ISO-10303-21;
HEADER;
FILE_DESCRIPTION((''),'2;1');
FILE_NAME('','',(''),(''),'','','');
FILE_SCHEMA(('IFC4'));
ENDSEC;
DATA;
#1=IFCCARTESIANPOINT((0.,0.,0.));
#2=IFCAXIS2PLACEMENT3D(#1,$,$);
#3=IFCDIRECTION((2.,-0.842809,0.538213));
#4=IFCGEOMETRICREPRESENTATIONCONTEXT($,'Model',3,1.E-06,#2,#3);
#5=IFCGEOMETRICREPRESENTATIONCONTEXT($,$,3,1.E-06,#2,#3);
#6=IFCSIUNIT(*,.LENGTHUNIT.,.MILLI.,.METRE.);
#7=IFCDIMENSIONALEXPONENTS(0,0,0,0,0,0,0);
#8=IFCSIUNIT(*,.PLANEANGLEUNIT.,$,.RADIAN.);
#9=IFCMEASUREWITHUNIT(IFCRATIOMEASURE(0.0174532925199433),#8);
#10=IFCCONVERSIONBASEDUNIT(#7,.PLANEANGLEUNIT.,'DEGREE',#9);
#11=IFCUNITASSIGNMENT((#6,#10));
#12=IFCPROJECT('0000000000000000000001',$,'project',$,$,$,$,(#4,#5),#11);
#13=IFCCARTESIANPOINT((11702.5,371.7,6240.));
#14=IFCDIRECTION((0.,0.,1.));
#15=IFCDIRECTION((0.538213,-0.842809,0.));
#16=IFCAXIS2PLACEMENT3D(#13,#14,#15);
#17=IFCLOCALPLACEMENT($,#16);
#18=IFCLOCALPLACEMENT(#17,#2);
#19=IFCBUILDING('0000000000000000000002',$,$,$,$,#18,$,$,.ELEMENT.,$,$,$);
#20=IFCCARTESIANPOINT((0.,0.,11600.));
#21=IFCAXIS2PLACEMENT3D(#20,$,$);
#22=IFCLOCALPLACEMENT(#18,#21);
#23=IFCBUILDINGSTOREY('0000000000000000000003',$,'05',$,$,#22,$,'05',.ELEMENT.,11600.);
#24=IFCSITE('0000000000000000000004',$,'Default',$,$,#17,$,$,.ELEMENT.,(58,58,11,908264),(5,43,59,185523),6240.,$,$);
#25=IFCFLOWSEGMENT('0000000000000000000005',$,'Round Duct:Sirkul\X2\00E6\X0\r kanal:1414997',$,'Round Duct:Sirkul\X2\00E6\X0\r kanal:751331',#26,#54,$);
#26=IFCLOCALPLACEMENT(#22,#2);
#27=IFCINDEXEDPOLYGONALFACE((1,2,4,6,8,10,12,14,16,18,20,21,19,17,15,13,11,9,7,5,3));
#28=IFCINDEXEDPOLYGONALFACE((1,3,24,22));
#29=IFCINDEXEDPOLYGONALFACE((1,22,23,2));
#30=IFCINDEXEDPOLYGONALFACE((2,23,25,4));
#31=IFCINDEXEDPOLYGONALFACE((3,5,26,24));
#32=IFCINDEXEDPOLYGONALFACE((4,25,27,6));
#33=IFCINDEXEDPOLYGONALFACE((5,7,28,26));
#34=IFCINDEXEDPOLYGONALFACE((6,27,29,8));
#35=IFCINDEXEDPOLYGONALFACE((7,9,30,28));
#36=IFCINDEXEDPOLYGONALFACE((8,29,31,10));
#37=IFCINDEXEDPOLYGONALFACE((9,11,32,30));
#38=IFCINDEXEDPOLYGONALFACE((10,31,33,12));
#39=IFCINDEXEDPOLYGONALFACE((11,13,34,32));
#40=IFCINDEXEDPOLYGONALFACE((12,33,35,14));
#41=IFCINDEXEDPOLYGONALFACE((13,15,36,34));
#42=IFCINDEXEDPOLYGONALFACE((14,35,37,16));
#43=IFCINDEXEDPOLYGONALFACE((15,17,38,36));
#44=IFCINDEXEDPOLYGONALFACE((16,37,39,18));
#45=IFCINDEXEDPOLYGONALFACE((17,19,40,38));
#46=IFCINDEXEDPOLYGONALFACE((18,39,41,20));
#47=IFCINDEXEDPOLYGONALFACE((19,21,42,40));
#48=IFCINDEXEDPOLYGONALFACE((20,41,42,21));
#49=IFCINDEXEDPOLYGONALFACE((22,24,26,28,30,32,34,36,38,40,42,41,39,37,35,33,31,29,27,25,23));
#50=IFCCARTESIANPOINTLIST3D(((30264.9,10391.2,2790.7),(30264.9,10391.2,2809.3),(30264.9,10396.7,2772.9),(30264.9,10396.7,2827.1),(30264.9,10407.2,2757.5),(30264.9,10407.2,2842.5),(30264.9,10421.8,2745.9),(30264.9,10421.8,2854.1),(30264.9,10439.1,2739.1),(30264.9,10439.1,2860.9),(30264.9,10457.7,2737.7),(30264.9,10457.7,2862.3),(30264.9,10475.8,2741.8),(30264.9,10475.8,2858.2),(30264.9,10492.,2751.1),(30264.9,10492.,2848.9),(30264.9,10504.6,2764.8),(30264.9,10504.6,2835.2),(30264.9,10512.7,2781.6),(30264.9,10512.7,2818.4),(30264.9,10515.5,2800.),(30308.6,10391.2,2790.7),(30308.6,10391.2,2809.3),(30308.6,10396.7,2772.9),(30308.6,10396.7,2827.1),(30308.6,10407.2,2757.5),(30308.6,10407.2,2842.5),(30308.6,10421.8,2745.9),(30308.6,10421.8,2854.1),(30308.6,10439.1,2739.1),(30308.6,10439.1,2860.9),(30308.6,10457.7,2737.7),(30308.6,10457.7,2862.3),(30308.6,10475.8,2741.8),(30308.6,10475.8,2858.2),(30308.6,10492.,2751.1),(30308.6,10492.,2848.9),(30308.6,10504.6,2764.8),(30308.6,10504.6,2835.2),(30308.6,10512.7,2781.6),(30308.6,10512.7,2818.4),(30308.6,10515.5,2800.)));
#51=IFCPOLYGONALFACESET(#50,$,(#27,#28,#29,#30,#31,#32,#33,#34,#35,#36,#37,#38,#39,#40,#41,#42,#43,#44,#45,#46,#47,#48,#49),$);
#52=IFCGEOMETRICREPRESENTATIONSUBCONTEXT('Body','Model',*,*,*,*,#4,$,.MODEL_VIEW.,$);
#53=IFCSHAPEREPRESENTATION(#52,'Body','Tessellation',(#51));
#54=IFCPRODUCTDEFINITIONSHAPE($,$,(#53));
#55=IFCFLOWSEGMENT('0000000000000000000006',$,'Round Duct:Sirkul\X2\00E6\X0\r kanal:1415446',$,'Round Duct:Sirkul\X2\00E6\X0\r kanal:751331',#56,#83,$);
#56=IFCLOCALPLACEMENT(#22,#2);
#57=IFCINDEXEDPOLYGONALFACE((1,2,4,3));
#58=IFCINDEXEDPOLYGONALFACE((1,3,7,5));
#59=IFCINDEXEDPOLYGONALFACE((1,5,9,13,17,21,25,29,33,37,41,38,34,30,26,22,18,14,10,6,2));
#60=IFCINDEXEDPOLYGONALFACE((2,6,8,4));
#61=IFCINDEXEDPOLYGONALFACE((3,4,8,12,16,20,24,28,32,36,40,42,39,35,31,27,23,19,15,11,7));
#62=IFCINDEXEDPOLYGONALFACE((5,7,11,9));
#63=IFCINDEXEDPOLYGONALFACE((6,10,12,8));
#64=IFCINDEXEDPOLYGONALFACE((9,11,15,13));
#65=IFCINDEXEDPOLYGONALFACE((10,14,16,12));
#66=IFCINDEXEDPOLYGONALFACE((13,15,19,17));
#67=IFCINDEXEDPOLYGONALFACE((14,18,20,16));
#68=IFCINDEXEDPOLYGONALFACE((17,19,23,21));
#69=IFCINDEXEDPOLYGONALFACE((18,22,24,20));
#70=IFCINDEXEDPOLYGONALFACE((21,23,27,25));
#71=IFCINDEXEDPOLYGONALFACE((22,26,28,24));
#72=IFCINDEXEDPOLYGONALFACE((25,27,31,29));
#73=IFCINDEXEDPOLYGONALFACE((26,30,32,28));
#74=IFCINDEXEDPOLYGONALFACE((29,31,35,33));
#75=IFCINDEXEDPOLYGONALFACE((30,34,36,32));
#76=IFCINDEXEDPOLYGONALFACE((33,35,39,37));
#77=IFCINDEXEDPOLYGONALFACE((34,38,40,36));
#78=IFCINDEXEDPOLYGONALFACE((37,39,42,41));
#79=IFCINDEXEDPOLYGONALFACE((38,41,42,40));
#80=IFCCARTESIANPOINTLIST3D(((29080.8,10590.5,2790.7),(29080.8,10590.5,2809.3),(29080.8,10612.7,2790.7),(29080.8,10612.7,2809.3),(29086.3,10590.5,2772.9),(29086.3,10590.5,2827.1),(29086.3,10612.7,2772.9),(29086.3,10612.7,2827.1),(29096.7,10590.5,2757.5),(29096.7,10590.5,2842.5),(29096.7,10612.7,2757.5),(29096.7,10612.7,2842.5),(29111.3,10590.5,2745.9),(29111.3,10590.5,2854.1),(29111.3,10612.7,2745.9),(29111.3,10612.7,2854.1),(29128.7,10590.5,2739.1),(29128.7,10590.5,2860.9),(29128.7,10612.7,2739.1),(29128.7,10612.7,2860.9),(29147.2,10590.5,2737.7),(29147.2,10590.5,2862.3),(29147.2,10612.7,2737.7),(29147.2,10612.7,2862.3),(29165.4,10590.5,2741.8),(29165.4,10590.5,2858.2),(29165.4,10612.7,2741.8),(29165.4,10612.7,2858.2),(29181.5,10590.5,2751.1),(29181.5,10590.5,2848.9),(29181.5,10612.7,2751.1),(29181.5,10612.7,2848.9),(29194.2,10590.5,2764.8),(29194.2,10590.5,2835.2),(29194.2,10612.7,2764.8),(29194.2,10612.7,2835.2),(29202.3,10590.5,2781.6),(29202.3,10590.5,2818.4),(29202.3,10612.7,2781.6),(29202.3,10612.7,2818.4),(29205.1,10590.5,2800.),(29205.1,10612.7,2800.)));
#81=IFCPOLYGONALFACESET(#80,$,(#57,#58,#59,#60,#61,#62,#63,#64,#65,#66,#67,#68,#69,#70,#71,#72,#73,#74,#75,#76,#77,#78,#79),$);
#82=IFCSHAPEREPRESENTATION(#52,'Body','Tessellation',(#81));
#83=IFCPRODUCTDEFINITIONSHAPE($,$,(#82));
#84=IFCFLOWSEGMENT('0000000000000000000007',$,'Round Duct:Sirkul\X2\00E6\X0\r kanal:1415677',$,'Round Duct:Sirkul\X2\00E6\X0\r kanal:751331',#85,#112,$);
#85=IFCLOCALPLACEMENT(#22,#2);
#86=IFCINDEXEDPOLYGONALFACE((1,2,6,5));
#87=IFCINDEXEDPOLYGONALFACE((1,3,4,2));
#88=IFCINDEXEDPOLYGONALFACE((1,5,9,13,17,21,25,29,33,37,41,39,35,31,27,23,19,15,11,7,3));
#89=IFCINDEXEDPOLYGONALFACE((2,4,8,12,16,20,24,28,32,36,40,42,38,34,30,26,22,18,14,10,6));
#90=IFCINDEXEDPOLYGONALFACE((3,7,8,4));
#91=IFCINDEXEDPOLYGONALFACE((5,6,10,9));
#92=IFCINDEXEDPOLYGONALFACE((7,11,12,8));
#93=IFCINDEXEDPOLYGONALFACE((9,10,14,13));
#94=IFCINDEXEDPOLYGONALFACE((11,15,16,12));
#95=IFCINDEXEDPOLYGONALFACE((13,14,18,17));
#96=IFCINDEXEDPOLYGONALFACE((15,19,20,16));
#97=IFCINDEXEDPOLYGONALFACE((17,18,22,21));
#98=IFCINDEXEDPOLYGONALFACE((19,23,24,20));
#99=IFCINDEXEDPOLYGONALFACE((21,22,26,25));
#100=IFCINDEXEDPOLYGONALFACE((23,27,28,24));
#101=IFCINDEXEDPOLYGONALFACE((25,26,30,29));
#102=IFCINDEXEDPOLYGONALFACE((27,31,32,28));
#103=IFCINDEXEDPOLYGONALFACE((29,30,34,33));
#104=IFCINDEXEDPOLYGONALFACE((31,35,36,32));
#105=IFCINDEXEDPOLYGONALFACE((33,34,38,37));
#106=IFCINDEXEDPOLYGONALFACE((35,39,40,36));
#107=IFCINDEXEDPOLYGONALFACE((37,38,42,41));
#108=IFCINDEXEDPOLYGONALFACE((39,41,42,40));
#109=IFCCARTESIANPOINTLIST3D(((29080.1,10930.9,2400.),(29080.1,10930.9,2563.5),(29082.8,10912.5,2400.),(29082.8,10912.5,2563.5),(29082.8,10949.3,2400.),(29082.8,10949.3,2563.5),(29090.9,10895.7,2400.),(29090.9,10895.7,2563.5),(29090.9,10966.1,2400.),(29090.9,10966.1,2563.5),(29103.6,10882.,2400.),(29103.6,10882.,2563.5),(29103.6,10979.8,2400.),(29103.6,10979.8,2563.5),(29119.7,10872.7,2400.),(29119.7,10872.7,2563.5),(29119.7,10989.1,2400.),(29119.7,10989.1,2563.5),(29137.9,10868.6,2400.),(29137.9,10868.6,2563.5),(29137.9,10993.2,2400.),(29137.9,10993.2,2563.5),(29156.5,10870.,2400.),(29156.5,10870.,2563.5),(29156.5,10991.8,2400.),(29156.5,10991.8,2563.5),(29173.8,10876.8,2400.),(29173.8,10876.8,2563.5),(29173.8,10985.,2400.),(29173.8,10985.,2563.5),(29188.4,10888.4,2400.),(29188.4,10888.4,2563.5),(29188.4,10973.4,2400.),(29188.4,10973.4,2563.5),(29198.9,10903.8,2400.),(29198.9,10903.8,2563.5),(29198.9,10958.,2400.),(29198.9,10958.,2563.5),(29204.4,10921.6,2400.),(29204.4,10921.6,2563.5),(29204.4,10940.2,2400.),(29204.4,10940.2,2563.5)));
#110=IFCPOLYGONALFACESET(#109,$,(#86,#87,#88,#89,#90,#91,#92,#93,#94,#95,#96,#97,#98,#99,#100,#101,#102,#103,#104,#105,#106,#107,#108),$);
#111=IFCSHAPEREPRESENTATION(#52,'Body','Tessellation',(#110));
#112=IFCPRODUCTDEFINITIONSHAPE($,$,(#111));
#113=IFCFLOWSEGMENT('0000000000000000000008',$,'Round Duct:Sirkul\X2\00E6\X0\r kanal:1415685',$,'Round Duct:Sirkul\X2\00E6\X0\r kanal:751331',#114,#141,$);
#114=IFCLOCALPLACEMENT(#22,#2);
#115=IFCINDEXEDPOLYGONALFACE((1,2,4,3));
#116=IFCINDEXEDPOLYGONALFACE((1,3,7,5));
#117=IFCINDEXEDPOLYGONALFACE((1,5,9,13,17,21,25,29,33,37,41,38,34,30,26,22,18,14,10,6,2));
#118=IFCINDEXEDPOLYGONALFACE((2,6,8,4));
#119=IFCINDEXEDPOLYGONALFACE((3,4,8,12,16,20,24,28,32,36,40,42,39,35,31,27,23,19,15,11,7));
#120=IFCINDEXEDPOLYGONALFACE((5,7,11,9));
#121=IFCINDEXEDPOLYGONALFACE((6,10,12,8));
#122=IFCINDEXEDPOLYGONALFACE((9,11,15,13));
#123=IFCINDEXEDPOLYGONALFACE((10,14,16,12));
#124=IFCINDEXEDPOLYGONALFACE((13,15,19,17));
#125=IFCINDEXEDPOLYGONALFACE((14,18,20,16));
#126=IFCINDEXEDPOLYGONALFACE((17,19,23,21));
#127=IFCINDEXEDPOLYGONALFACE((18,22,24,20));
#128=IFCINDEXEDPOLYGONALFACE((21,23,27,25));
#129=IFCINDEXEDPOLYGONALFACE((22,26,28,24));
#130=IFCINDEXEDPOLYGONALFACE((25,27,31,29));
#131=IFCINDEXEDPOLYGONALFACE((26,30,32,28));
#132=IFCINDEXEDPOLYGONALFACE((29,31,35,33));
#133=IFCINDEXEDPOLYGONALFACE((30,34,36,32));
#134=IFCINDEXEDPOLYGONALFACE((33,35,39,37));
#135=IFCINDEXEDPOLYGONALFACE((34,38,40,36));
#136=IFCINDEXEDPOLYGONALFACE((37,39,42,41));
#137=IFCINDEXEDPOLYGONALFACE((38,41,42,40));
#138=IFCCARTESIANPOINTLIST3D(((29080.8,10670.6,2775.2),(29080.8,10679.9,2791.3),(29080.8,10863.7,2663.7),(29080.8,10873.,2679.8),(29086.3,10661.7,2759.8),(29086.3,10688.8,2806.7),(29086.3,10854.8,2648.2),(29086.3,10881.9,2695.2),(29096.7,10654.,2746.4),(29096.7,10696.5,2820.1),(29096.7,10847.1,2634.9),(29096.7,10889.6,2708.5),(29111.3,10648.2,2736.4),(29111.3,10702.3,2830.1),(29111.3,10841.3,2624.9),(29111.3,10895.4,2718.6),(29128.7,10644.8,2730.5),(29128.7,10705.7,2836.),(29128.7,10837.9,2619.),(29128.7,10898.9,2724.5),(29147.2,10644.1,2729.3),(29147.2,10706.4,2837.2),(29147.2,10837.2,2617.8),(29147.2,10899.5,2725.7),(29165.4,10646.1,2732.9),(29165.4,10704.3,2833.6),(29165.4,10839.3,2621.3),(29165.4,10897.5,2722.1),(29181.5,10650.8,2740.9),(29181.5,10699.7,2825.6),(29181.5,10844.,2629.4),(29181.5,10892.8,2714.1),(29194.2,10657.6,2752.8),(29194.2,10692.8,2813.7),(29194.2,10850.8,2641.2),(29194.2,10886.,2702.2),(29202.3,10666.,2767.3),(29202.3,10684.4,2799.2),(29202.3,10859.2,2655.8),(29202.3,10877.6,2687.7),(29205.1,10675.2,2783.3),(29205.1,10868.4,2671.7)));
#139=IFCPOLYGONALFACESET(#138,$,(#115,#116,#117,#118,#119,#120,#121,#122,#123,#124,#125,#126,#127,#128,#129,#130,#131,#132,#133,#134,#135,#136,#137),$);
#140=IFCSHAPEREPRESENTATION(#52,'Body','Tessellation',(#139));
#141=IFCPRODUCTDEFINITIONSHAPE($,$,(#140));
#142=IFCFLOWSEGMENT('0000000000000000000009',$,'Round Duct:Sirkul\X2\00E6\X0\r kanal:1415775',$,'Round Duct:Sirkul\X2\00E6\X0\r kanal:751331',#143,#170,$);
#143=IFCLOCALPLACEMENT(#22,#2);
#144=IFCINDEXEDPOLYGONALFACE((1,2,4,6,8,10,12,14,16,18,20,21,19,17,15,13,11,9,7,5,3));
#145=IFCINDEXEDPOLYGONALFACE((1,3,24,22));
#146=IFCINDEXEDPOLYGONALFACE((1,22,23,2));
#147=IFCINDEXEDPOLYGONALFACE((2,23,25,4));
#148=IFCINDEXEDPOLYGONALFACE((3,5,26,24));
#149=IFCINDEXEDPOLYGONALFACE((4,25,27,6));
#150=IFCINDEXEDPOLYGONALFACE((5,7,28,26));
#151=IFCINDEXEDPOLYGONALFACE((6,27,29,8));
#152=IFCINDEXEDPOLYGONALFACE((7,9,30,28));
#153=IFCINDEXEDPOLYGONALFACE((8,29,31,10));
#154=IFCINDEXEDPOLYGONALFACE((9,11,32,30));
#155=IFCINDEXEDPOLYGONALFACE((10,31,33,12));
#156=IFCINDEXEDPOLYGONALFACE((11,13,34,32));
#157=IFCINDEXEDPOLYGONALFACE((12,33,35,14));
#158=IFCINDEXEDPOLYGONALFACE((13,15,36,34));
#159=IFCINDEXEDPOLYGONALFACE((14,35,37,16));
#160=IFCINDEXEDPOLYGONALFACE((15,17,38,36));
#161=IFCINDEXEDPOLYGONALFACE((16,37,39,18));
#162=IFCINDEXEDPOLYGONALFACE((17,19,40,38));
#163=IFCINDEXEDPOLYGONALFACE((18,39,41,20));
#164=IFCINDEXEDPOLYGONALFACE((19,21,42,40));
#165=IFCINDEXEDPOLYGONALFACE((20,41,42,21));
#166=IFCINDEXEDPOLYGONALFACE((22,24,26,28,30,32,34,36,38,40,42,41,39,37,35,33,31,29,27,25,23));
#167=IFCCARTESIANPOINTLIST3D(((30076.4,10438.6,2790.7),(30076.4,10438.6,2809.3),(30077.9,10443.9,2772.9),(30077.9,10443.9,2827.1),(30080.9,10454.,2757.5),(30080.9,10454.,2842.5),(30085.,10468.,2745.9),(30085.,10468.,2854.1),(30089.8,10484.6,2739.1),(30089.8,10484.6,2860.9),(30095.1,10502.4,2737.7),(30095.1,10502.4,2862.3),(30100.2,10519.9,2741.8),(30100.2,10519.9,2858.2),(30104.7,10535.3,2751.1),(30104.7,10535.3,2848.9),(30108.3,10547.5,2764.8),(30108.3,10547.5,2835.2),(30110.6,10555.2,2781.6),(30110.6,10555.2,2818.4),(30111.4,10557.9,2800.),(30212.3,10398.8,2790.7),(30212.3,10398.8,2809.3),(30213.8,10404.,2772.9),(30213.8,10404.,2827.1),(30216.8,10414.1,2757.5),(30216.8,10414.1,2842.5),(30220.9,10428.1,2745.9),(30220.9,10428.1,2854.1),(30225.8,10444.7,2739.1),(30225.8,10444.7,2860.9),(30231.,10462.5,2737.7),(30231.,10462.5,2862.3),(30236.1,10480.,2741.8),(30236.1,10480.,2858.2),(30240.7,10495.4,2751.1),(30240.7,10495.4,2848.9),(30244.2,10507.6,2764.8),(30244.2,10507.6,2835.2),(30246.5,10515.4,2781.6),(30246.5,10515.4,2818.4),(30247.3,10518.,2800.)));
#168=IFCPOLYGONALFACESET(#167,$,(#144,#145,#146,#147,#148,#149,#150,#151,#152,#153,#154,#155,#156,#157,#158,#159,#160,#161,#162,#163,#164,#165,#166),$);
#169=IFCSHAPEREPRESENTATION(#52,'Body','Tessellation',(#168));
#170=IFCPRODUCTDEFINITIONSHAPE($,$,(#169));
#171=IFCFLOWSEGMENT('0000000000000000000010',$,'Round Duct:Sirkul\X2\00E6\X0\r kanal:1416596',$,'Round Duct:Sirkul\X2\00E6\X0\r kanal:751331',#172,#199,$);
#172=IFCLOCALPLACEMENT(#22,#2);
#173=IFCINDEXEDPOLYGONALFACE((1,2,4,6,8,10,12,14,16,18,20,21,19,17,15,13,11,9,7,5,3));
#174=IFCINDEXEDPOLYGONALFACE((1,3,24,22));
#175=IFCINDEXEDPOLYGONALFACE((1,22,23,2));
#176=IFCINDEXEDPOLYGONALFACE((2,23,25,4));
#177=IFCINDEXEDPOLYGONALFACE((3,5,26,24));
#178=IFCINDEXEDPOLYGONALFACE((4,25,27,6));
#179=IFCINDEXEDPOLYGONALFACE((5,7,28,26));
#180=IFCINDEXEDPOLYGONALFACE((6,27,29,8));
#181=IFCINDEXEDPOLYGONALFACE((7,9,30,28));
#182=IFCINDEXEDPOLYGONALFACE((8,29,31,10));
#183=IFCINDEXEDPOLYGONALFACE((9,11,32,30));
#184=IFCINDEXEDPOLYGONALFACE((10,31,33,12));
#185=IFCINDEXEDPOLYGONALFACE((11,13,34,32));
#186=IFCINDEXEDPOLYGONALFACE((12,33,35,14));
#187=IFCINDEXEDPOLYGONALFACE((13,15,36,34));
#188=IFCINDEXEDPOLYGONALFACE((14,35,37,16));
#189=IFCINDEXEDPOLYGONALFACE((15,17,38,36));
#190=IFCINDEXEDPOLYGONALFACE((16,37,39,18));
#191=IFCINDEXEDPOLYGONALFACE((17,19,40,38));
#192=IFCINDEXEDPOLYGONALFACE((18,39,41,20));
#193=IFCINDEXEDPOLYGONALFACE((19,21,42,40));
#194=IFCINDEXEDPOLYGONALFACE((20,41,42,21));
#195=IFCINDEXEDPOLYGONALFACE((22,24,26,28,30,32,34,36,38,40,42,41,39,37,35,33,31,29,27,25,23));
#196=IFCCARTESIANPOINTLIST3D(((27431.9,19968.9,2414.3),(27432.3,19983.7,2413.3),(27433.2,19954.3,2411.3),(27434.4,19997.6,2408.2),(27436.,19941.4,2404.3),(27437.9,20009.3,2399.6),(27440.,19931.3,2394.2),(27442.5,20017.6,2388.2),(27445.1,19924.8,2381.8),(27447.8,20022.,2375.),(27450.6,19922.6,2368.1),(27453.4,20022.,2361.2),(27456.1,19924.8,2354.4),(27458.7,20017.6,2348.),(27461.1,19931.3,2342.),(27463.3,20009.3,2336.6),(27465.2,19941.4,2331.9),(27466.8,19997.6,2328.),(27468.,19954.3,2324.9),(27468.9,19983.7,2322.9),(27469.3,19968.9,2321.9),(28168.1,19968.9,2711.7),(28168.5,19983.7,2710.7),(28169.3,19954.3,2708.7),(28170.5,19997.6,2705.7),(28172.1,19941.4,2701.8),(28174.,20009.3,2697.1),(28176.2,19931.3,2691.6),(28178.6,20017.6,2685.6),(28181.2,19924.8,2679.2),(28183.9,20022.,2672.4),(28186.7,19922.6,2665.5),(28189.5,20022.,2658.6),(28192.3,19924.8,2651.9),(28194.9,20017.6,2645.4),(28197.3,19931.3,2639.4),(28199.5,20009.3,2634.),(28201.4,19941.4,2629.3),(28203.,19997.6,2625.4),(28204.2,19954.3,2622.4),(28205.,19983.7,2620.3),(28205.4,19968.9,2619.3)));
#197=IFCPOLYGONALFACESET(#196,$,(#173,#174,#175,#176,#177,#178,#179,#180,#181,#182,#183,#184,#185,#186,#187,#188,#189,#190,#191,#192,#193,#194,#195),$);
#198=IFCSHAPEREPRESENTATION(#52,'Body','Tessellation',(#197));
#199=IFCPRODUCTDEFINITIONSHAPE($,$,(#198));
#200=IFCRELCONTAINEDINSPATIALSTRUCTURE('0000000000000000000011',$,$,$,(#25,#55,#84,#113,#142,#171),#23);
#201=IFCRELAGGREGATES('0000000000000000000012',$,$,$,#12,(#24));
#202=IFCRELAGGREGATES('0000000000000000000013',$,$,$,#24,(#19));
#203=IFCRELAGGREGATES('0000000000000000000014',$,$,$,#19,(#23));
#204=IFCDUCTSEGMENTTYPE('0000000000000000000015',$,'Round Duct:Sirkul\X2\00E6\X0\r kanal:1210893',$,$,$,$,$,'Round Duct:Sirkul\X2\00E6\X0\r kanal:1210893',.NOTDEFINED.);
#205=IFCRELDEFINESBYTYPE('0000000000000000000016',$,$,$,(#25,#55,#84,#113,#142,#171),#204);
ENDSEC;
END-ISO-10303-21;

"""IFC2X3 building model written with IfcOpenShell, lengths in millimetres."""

from ifc_helpers import new_model, entity, si_unit, converted_unit, direction, frame, frame_2d, origin, origin_2d_with_axis, place, context, subcontext, project, spatial, circle, extrude, type_object, element, save


model = new_model("IFC2X3")

# Units and contexts
model_context = context("Model", 3, precision=1e-06, world=origin(), true_north=direction((2.0, -0.842809, 0.538213)))
context_of_model = context(None, 3, precision=1e-06, world=origin(), true_north=direction((2.0, -0.842809, 0.538213)))
body_context = subcontext(model_context, "Body", "Model", "MODEL_VIEW")
ifc_project = project(units=[si_unit("LENGTHUNIT", "METRE", prefix="MILLI"), converted_unit("PLANEANGLEUNIT", "DEGREE", entity("IfcRatioMeasure", 0.0174532925199433), si_unit("PLANEANGLEUNIT", "RADIAN"), dimensions=[0, 0, 0, 0, 0, 0, 0])], contexts=[model_context, context_of_model])

# Site, building, storey
site_placement = place(None, frame((11702.5, 371.7, 6240.0), z_axis=(0.0, 0.0, 1.0), x_axis=(0.538213, -0.842809, 0.0)))
site = spatial("IfcSite", under=ifc_project, at=site_placement, Name="Default", CompositionType="ELEMENT", RefLatitude=(58, 58, 11, 908264), RefLongitude=(5, 43, 59, 185523), RefElevation=6240.0)
building_placement = place(site_placement, origin())
building = spatial("IfcBuilding", under=site, at=building_placement, CompositionType="ELEMENT")
storey_placement = place(building_placement, frame((0.0, 0.0, 11600.0)))
storey = spatial("IfcBuildingStorey", under=building, at=storey_placement, Name="05", LongName="05", CompositionType="ELEMENT", Elevation=11600.0)

# Flow segments
duct_segment_type = type_object("IfcDuctSegmentType", Name="Round Duct:Sirkulær kanal:1210893", ElementType="Round Duct:Sirkulær kanal:1210893", PredefinedType="NOTDEFINED")
flow_segment_1_placement = place(storey_placement, origin())
element("IfcFlowSegment", 1, at=flow_segment_1_placement, inside=storey, type_object=duct_segment_type, Name="Round Duct:Sirkulær kanal:1414997", ObjectType="Round Duct:Sirkulær kanal:751331", context=body_context, shape_type="SweptSolid", body=[
    extrude(circle(Radius=62.5, at=frame_2d((0.0, 0.0), x_axis=(1.0, 0.0))), frame((30264.9, 10453.0, 2800.0), z_axis=(1.0, 0.0, 0.0), x_axis=(0.0, 1.0, 0.0)), (0.0, 0.0, 1.0), 43.8),
])
flow_segment_2_placement = place(storey_placement, origin())
element("IfcFlowSegment", 2, at=flow_segment_2_placement, inside=storey, type_object=duct_segment_type, Name="Round Duct:Sirkulær kanal:1415446", ObjectType="Round Duct:Sirkulær kanal:751331", context=body_context, shape_type="SweptSolid", body=[
    extrude(circle(Radius=62.5, at=frame_2d((0.0, 0.0), x_axis=(1.0, 0.0))), frame((29142.6, 10590.5, 2800.0), z_axis=(0.0, 1.0, 0.0), x_axis=(1.0, 0.0, 0.0)), (0.0, 0.0, 1.0), 22.2),
])
flow_segment_3_placement = place(storey_placement, origin())
element("IfcFlowSegment", 3, at=flow_segment_3_placement, inside=storey, type_object=duct_segment_type, Name="Round Duct:Sirkulær kanal:1415677", ObjectType="Round Duct:Sirkulær kanal:751331", context=body_context, shape_type="SweptSolid", body=[
    extrude(circle(Radius=62.5, at=frame_2d((0.0, 0.0), x_axis=(1.0, 0.0))), frame((29142.6, 10930.9, 2400.0), z_axis=(0.0, 0.0, 1.0), x_axis=(-1.0, 0.0, 0.0)), (0.0, 0.0, 1.0), 163.5),
])
flow_segment_4_placement = place(storey_placement, origin())
element("IfcFlowSegment", 4, at=flow_segment_4_placement, inside=storey, type_object=duct_segment_type, Name="Round Duct:Sirkulær kanal:1415685", ObjectType="Round Duct:Sirkulær kanal:751331", context=body_context, shape_type="SweptSolid", body=[
    extrude(circle(Radius=62.5, at=frame_2d((0.0, 0.0), x_axis=(1.0, 0.0))), frame((29142.6, 10868.4, 2671.7), z_axis=(0.0, -0.866025, 0.5), x_axis=(1.0, 0.0, 0.0)), (0.0, 0.0, 1.0), 223.0),
])
flow_segment_5_placement = place(storey_placement, origin())
element("IfcFlowSegment", 5, at=flow_segment_5_placement, inside=storey, type_object=duct_segment_type, Name="Round Duct:Sirkulær kanal:1415775", ObjectType="Round Duct:Sirkulær kanal:751331", context=body_context, shape_type="SweptSolid", body=[
    extrude(circle(Radius=62.5, at=origin_2d_with_axis()), frame((30093.8, 10497.9, 2800.0), z_axis=(0.959541, -0.281571, 0.0), x_axis=(0.281571, 0.959541, 0.0)), (0.0, 0.0, 1.0), 141.7),
])
flow_segment_6_placement = place(storey_placement, origin())
element("IfcFlowSegment", 6, at=flow_segment_6_placement, inside=storey, type_object=duct_segment_type, Name="Round Duct:Sirkulær kanal:1416596", ObjectType="Round Duct:Sirkulær kanal:751331", context=body_context, shape_type="SweptSolid", body=[
    extrude(circle(Radius=50.0, at=origin_2d_with_axis()), frame((27450.6, 19972.6, 2368.1), z_axis=(0.927184, 0.0, 0.374607), x_axis=(0.0, -1.0, 0.0)), (0.0, 0.0, 1.0), 794.0),
])

save(model, "model.ifc")
